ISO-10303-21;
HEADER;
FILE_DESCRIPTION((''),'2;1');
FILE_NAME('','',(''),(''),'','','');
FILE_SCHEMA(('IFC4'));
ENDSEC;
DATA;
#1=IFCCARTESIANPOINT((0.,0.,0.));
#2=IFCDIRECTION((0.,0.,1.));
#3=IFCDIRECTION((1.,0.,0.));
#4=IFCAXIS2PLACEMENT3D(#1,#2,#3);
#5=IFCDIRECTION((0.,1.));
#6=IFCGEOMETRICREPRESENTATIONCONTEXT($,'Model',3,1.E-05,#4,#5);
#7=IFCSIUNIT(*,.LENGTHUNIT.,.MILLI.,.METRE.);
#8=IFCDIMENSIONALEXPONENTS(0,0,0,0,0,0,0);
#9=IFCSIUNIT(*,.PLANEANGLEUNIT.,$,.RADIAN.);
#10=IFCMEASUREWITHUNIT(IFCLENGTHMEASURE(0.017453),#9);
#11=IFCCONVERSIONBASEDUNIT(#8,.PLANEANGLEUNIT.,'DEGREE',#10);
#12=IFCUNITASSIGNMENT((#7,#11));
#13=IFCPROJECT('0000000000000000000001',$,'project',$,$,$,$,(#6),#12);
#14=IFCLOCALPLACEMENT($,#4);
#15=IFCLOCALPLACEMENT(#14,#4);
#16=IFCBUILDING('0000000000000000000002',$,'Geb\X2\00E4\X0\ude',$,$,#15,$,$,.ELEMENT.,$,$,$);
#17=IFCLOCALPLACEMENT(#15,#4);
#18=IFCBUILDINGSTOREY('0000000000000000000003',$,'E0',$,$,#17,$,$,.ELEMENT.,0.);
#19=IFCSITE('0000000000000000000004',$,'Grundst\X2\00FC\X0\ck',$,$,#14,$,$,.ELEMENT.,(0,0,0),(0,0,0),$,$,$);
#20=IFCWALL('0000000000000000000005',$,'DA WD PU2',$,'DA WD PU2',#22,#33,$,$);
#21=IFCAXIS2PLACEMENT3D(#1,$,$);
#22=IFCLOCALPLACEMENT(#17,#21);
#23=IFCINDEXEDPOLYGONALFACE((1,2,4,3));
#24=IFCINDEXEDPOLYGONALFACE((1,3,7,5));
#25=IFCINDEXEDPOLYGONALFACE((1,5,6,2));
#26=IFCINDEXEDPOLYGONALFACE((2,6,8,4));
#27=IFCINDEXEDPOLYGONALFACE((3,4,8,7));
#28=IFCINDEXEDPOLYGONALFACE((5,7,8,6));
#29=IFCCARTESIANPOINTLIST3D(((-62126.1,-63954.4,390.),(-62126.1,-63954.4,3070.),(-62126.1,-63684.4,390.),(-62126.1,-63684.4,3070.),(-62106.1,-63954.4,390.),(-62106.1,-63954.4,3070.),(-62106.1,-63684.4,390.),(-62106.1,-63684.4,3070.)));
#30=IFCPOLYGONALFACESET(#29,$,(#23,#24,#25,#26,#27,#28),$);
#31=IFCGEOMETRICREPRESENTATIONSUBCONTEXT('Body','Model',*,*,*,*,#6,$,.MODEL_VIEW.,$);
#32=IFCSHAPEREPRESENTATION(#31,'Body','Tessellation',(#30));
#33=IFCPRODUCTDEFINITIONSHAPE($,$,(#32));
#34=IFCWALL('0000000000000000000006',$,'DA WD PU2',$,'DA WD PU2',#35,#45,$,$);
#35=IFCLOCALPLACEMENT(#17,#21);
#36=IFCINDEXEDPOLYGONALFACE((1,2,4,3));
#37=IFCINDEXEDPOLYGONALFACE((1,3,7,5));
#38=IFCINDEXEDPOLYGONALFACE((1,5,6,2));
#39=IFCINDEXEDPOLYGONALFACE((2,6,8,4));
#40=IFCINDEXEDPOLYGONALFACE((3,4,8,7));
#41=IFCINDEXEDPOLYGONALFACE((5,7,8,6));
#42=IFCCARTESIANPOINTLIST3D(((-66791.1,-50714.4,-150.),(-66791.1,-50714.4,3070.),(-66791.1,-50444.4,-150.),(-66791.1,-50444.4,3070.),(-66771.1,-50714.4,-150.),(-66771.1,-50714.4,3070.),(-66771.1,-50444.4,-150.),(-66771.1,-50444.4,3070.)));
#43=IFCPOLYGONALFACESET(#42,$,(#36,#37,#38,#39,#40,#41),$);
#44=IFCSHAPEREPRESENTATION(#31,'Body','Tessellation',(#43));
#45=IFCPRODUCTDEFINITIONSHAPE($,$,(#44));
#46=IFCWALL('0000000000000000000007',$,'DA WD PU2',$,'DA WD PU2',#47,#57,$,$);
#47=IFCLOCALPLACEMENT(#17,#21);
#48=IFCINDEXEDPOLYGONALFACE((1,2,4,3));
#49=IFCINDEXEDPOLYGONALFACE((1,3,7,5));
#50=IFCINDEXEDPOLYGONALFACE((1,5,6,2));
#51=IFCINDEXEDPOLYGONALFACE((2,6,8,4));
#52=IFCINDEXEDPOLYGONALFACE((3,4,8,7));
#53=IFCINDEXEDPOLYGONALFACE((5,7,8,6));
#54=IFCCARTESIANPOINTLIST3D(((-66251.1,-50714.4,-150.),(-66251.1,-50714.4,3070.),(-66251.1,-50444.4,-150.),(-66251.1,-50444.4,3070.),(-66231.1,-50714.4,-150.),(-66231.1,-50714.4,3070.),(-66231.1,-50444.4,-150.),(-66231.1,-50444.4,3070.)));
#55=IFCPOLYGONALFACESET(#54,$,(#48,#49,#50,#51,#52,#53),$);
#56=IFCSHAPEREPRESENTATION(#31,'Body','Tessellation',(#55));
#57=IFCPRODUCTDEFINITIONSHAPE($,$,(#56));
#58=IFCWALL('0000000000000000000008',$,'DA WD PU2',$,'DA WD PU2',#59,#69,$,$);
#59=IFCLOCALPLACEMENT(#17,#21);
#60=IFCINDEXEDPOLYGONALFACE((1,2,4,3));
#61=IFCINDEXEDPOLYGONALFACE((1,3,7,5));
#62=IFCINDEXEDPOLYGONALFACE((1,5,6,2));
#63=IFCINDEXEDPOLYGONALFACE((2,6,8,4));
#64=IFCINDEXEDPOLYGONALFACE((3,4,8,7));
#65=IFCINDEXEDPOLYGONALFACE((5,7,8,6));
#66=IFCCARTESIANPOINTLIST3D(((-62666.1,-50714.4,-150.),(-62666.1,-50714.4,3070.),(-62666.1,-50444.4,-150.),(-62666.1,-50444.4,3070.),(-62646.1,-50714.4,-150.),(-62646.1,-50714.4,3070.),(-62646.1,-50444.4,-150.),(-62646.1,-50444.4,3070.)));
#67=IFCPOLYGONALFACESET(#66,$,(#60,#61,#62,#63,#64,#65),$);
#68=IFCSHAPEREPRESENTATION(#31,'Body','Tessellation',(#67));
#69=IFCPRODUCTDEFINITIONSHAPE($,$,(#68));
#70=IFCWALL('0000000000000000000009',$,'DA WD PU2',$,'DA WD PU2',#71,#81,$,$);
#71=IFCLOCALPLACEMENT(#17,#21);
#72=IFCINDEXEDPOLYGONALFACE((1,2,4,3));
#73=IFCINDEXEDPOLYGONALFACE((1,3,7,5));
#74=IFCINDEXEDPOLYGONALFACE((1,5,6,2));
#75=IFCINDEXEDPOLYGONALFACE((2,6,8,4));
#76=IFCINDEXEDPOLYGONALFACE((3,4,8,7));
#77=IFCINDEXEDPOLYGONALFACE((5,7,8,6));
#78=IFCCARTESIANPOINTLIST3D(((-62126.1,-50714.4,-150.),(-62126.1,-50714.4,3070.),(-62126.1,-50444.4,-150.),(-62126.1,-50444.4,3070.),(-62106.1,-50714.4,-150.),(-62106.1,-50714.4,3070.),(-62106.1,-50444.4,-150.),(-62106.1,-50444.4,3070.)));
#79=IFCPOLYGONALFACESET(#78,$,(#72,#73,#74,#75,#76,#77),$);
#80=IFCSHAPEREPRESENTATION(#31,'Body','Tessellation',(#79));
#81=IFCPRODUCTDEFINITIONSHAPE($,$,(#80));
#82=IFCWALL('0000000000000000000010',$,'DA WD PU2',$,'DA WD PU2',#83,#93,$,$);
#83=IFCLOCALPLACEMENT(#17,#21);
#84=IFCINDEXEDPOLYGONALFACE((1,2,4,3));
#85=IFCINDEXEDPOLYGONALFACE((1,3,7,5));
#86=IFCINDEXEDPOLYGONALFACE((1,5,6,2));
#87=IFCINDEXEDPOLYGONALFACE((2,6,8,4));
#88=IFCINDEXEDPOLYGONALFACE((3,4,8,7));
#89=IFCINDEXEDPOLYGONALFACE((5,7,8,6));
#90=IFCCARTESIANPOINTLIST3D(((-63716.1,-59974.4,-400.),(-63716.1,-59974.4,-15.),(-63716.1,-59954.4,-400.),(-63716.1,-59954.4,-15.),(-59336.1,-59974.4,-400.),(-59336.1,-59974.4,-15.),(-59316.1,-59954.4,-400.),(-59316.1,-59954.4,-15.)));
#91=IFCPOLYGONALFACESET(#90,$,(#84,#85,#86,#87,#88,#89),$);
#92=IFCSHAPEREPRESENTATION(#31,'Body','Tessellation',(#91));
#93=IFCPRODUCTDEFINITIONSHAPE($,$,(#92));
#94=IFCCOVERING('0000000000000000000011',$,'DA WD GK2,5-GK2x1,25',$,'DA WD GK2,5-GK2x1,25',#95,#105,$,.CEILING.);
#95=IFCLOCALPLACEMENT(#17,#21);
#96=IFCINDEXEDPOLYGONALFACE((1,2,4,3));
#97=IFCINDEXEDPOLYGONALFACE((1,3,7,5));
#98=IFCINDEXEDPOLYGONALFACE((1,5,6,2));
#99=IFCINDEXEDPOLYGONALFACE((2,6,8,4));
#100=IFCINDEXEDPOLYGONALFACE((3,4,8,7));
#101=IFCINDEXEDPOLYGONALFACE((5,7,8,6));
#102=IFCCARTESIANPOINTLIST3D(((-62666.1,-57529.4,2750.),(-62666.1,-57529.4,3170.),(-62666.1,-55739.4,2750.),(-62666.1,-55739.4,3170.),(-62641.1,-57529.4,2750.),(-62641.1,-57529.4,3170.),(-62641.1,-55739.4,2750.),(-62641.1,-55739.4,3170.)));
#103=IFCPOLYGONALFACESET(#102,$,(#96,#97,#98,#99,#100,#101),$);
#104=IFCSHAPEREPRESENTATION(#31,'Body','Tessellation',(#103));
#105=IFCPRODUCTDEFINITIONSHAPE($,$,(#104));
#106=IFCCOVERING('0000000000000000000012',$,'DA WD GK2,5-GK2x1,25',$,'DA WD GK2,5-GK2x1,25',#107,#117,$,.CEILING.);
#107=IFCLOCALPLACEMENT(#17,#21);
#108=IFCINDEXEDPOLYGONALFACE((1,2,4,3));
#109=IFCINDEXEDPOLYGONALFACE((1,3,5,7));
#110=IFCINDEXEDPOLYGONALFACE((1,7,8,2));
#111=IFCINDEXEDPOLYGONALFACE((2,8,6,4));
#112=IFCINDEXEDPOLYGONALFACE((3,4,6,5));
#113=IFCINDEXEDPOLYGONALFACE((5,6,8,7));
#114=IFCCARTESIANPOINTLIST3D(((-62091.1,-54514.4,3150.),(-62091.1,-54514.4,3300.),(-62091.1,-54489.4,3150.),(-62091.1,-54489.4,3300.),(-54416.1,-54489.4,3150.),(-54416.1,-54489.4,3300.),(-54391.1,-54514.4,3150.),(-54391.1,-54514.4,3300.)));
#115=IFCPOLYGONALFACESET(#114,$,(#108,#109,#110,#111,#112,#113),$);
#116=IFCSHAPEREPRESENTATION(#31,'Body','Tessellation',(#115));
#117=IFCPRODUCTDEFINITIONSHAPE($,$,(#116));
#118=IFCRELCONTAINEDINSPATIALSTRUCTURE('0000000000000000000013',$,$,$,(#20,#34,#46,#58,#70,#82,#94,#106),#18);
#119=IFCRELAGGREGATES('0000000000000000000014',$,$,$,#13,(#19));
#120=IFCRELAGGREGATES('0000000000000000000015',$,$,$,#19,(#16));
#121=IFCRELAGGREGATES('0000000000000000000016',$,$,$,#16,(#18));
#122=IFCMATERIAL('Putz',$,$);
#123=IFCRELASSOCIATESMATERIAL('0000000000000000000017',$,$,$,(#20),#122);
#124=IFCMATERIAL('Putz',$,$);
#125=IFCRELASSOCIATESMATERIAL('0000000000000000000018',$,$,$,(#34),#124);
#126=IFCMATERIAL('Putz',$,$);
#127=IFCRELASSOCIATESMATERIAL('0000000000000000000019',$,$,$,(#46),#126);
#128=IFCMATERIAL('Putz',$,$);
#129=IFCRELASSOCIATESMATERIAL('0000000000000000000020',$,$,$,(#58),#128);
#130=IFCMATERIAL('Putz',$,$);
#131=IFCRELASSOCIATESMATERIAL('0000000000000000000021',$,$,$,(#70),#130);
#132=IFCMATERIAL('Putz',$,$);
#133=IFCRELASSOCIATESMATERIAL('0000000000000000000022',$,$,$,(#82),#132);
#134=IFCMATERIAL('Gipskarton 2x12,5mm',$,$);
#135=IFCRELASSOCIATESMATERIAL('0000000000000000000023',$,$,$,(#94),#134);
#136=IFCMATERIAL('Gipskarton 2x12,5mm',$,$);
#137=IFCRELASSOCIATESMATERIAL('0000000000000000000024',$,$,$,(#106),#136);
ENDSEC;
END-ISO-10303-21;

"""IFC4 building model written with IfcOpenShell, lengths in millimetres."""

from ifc_helpers import new_model, entity, si_unit, converted_unit, direction, frame, origin_with_axes, place, context, subcontext, project, spatial, line, indexed_curve, outline, extrude, material, element, save


model = new_model("IFC4")

# Units and contexts
model_context = context("Model", 3, precision=1e-05, world=origin_with_axes(), true_north=direction((0.0, 1.0)))
body_context = subcontext(model_context, "Body", "Model", "MODEL_VIEW")
ifc_project = project(units=[si_unit("LENGTHUNIT", "METRE", prefix="MILLI"), converted_unit("PLANEANGLEUNIT", "DEGREE", entity("IfcLengthMeasure", 0.017453), si_unit("PLANEANGLEUNIT", "RADIAN"), dimensions=[0, 0, 0, 0, 0, 0, 0])], contexts=[model_context])

# Site, building, storey
site_placement = place(None, origin_with_axes())
site = spatial("IfcSite", under=ifc_project, at=site_placement, Name="Grundstück", CompositionType="ELEMENT", RefLatitude=(0, 0, 0), RefLongitude=(0, 0, 0))
building_placement = place(site_placement, origin_with_axes())
building = spatial("IfcBuilding", under=site, at=building_placement, Name="Gebäude", CompositionType="ELEMENT")
storey_placement = place(building_placement, origin_with_axes())
storey = spatial("IfcBuildingStorey", under=building, at=storey_placement, Name="E0", CompositionType="ELEMENT", Elevation=0.0)

# Walls
ifc_material_1 = material(Name="Putz")
wall_1_placement = place(storey_placement, frame((-62116.1, -63684.4, 390.0), z_axis=(0.0, 0.0, 1.0), x_axis=(0.0, -1.0, 0.0)))
element("IfcWall", 1, at=wall_1_placement, inside=storey, material=ifc_material_1, Name="DA WD PU2", ObjectType="DA WD PU2", context=body_context, shape_type="SweptSolid", body=[
    extrude(outline(indexed_curve([(0.0, -10.0), (0.0, 10.0), (270.0, 10.0), (270.0, -10.0)], segments=[line(1, 2), line(2, 3), line(3, 4), line(4, 1)])), origin_with_axes(), (0.0, 0.0, 1.0), 2680.0),
])
ifc_material_2 = material(Name="Putz")
wall_2_placement = place(storey_placement, frame((-66781.1, -50714.4, -150.0), z_axis=(0.0, 0.0, 1.0), x_axis=(0.0, 1.0, 0.0)))
element("IfcWall", 2, at=wall_2_placement, inside=storey, material=ifc_material_2, Name="DA WD PU2", ObjectType="DA WD PU2", context=body_context, shape_type="SweptSolid", body=[
    extrude(outline(indexed_curve([(0.0, -10.0), (0.0, 10.0), (270.0, 10.0), (270.0, -10.0)], segments=[line(1, 2), line(2, 3), line(3, 4), line(4, 1)])), origin_with_axes(), (0.0, 0.0, 1.0), 3220.0),
])
ifc_material_3 = material(Name="Putz")
wall_3_placement = place(storey_placement, frame((-66241.1, -50714.4, -150.0), z_axis=(0.0, 0.0, 1.0), x_axis=(0.0, 1.0, 0.0)))
element("IfcWall", 3, at=wall_3_placement, inside=storey, material=ifc_material_3, Name="DA WD PU2", ObjectType="DA WD PU2", context=body_context, shape_type="SweptSolid", body=[
    extrude(outline(indexed_curve([(0.0, -10.0), (0.0, 10.0), (270.0, 10.0), (270.0, -10.0)], segments=[line(1, 2), line(2, 3), line(3, 4), line(4, 1)])), origin_with_axes(), (0.0, 0.0, 1.0), 3220.0),
])
ifc_material_4 = material(Name="Putz")
wall_4_placement = place(storey_placement, frame((-62656.1, -50714.4, -150.0), z_axis=(0.0, 0.0, 1.0), x_axis=(0.0, 1.0, 0.0)))
element("IfcWall", 4, at=wall_4_placement, inside=storey, material=ifc_material_4, Name="DA WD PU2", ObjectType="DA WD PU2", context=body_context, shape_type="SweptSolid", body=[
    extrude(outline(indexed_curve([(0.0, -10.0), (0.0, 10.0), (270.0, 10.0), (270.0, -10.0)], segments=[line(1, 2), line(2, 3), line(3, 4), line(4, 1)])), origin_with_axes(), (0.0, 0.0, 1.0), 3220.0),
])
ifc_material_5 = material(Name="Putz")
wall_5_placement = place(storey_placement, frame((-62116.1, -50714.4, -150.0), z_axis=(0.0, 0.0, 1.0), x_axis=(0.0, 1.0, 0.0)))
element("IfcWall", 5, at=wall_5_placement, inside=storey, material=ifc_material_5, Name="DA WD PU2", ObjectType="DA WD PU2", context=body_context, shape_type="SweptSolid", body=[
    extrude(outline(indexed_curve([(0.0, -10.0), (0.0, 10.0), (270.0, 10.0), (270.0, -10.0)], segments=[line(1, 2), line(2, 3), line(3, 4), line(4, 1)])), origin_with_axes(), (0.0, 0.0, 1.0), 3220.0),
])
ifc_material_6 = material(Name="Putz")
wall_6_placement = place(storey_placement, frame((-63716.1, -59964.4, -400.0), z_axis=(0.0, 0.0, 1.0), x_axis=(1.0, 0.0, 0.0)))
element("IfcWall", 6, at=wall_6_placement, inside=storey, material=ifc_material_6, Name="DA WD PU2", ObjectType="DA WD PU2", context=body_context, shape_type="SweptSolid", body=[
    extrude(outline(indexed_curve([(0.0, -10.0), (0.0, 10.0), (4400.0, 10.0), (4380.0, -10.0)], segments=[line(1, 2), line(2, 3), line(3, 4), line(4, 1)])), origin_with_axes(), (0.0, 0.0, 1.0), 385.0),
])

# Coverings
ifc_material_7 = material(Name="Gipskarton 2x12,5mm")
covering_1_placement = place(storey_placement, frame((-62653.6, -57529.4, 2750.0), z_axis=(0.0, 0.0, 1.0), x_axis=(0.0, 1.0, 0.0)))
element("IfcCovering", 7, at=covering_1_placement, inside=storey, material=ifc_material_7, Name="DA WD GK2,5-GK2x1,25", ObjectType="DA WD GK2,5-GK2x1,25", PredefinedType="CEILING", context=body_context, shape_type="SweptSolid", body=[
    extrude(outline(indexed_curve([(0.0, -12.5), (0.0, 12.5), (1790.0, 12.5), (1790.0, -12.5)], segments=[line(1, 2), line(2, 3), line(3, 4), line(4, 1)])), origin_with_axes(), (0.0, 0.0, 1.0), 420.0),
])
ifc_material_8 = material(Name="Gipskarton 2x12,5mm")
covering_2_placement = place(storey_placement, frame((-62091.1, -54501.9, 3150.0), z_axis=(0.0, 0.0, 1.0), x_axis=(1.0, 0.0, 0.0)))
element("IfcCovering", 8, at=covering_2_placement, inside=storey, material=ifc_material_8, Name="DA WD GK2,5-GK2x1,25", ObjectType="DA WD GK2,5-GK2x1,25", PredefinedType="CEILING", context=body_context, shape_type="SweptSolid", body=[
    extrude(outline(indexed_curve([(0.0, -12.5), (0.0, 12.5), (7675.0, 12.5), (7700.0, -12.5)], segments=[line(1, 2), line(2, 3), line(3, 4), line(4, 1)])), origin_with_axes(), (0.0, 0.0, 1.0), 150.0),
])

save(model, "model.ifc")
